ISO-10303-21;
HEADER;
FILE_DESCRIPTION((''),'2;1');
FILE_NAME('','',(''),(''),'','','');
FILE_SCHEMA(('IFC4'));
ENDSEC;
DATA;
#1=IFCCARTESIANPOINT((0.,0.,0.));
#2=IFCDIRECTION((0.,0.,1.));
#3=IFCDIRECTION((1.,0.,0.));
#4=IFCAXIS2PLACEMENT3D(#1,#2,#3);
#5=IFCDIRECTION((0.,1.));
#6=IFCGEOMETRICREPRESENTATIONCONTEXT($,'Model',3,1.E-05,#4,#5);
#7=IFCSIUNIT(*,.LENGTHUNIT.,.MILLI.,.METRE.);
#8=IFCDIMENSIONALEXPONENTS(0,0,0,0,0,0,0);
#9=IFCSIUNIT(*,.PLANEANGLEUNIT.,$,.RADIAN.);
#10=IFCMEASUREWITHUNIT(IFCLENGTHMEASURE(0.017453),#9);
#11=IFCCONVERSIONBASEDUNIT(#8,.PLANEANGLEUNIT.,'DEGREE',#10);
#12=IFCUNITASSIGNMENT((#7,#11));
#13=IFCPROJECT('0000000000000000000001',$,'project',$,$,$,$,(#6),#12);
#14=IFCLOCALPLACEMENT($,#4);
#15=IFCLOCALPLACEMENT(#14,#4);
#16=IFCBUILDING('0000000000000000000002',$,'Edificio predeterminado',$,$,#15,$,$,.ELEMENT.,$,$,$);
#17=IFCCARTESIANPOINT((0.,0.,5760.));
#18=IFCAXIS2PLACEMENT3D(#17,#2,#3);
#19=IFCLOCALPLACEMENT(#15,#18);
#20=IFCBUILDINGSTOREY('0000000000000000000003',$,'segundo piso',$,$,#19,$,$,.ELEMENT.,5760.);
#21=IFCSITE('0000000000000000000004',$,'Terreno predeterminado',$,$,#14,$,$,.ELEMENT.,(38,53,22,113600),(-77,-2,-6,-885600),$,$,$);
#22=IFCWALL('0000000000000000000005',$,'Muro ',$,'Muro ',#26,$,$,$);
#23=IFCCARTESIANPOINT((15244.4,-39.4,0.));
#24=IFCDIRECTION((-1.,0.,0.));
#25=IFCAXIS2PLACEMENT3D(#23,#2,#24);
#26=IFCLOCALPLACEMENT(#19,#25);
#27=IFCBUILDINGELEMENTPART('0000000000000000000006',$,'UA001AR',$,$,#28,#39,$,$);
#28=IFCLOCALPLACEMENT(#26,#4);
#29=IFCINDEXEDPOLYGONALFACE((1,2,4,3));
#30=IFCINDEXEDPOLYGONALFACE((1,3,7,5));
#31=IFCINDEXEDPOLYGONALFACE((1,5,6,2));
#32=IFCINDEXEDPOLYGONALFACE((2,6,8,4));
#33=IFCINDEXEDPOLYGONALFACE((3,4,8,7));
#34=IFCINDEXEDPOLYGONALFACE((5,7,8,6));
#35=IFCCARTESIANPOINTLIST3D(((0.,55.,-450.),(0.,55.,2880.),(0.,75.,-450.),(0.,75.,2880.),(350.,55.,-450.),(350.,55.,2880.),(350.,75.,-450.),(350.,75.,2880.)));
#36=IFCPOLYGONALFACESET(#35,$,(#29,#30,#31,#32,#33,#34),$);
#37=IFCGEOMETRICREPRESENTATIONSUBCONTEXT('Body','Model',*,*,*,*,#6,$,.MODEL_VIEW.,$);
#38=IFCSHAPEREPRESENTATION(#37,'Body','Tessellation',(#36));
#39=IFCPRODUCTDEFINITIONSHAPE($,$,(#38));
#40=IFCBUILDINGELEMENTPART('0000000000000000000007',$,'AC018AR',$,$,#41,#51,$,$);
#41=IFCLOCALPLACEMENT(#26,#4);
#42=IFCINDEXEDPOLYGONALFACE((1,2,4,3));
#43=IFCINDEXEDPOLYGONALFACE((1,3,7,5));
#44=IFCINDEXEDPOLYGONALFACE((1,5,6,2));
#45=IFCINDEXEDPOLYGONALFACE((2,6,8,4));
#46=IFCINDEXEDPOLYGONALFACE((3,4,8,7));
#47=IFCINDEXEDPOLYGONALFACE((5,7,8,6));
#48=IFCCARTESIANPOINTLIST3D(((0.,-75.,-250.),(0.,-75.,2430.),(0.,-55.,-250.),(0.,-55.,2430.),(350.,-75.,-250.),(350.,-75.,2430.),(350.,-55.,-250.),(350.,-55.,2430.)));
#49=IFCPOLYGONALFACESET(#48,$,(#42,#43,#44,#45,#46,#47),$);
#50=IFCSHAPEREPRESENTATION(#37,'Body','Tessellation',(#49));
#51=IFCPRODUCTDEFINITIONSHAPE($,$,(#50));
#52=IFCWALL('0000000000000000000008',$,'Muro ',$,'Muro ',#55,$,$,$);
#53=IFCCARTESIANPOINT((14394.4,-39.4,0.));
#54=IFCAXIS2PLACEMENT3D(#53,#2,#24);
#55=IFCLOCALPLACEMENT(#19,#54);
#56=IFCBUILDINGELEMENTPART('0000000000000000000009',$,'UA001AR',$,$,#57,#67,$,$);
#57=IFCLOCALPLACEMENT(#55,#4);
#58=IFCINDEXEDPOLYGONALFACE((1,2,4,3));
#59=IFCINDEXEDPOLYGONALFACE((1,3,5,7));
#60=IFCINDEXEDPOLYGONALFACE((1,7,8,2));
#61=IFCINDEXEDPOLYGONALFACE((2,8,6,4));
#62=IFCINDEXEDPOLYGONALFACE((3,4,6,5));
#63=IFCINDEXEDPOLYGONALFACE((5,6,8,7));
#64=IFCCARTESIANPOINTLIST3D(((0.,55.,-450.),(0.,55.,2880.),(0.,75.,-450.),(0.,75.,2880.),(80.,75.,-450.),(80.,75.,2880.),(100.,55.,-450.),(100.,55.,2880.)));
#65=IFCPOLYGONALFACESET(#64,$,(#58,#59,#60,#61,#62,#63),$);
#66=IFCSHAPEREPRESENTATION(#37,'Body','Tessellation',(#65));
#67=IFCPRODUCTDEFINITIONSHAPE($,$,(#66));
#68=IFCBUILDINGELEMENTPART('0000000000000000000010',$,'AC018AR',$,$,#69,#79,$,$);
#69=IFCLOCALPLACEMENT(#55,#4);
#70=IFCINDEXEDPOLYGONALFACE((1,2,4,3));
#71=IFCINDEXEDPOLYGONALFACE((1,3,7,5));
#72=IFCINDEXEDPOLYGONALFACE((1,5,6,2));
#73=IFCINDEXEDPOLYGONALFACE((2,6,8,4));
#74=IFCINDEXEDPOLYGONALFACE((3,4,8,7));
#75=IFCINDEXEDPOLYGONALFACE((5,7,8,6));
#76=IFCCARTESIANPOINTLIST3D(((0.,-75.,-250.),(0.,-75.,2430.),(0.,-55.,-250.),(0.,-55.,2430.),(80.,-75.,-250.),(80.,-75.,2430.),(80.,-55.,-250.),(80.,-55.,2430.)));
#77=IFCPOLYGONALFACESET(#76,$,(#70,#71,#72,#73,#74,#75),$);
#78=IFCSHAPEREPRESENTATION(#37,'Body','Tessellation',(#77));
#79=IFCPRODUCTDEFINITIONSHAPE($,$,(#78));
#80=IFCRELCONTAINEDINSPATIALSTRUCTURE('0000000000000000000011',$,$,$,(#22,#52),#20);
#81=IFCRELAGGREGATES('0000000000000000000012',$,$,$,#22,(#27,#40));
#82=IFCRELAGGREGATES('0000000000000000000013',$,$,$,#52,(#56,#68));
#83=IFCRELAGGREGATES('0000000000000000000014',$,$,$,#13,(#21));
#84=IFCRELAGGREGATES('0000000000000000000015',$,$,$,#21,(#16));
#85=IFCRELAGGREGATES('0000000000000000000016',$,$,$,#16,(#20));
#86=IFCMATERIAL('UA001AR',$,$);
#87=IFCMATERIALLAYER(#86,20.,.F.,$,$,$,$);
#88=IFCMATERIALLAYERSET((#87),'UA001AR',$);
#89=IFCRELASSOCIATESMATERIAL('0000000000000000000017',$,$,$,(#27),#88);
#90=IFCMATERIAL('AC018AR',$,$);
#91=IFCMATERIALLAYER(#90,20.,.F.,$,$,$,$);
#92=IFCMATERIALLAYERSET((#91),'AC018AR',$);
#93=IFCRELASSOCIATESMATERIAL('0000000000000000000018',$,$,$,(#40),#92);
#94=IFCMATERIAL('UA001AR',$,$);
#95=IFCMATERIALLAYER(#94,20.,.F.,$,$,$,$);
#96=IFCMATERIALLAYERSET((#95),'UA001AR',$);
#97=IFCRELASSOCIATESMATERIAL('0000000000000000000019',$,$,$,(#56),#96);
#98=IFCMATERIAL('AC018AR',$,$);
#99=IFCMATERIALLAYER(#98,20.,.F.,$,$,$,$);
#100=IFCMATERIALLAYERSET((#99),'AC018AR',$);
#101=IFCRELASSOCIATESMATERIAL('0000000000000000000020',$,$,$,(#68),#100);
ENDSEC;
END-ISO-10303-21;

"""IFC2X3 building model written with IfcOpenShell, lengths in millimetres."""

from ifc_helpers import new_model, entity, si_unit, converted_unit, direction, frame, origin_with_axes, place, context, subcontext, project, spatial, polyline, outline, extrude, material, layer, layer_set, layer_usage, element, aggregate, save


model = new_model("IFC2X3")

# Units and contexts
model_context = context("Model", 3, precision=1e-05, world=origin_with_axes(), true_north=direction((0.0, 1.0)))
body_context = subcontext(model_context, "Body", "Model", "MODEL_VIEW")
ifc_project = project(units=[si_unit("LENGTHUNIT", "METRE", prefix="MILLI"), converted_unit("PLANEANGLEUNIT", "DEGREE", entity("IfcLengthMeasure", 0.017453), si_unit("PLANEANGLEUNIT", "RADIAN"), dimensions=[0, 0, 0, 0, 0, 0, 0])], contexts=[model_context])

# Site, building, storey
site_placement = place(None, origin_with_axes())
site = spatial("IfcSite", under=ifc_project, at=site_placement, Name="Terreno predeterminado", CompositionType="ELEMENT", RefLatitude=(38, 53, 22, 113600), RefLongitude=(-77, -2, -6, -885600))
building_placement = place(site_placement, origin_with_axes())
building = spatial("IfcBuilding", under=site, at=building_placement, Name="Edificio predeterminado", CompositionType="ELEMENT")
storey_placement = place(building_placement, frame((0.0, 0.0, 5760.0), z_axis=(0.0, 0.0, 1.0), x_axis=(1.0, 0.0, 0.0)))
storey = spatial("IfcBuildingStorey", under=building, at=storey_placement, Name="segundo piso", CompositionType="ELEMENT", Elevation=5760.0)

# Walls, building element parts
wall_1_placement = place(storey_placement, frame((15244.4, -39.4, 0.0), z_axis=(0.0, 0.0, 1.0), x_axis=(-1.0, 0.0, 0.0)))
wall_1 = element("IfcWall", 1, at=wall_1_placement, inside=storey, Name="Muro ", ObjectType="Muro ")
ifc_material_1 = material(Name="UA001AR")
ifc_layer_1 = layer(ifc_material_1, 20.0, ventilated=False)
ifc_layer_set_1 = layer_set([ifc_layer_1], Name="UA001AR")
ifc_layer_usage_1 = layer_usage(ifc_layer_set_1, "AXIS2", "NEGATIVE", -75.0)
building_element_part_1_placement = place(wall_1_placement, origin_with_axes())
building_element_part_1 = element("IfcBuildingElementPart", 2, at=building_element_part_1_placement, material=ifc_layer_usage_1, Name="UA001AR", context=body_context, shape_type="SweptSolid", body=[
    extrude(outline(polyline([(350.0, 75.0), (350.0, 55.0), (0.0, 55.0), (0.0, 75.0), (350.0, 75.0)])), frame((0.0, 0.0, -450.0), z_axis=(0.0, 0.0, 1.0), x_axis=(1.0, 0.0, 0.0)), (0.0, 0.0, 1.0), 3330.0),
])
ifc_material_2 = material(Name="AC018AR")
ifc_layer_2 = layer(ifc_material_2, 20.0, ventilated=False)
ifc_layer_set_2 = layer_set([ifc_layer_2], Name="AC018AR")
ifc_layer_usage_2 = layer_usage(ifc_layer_set_2, "AXIS2", "NEGATIVE", 55.0)
building_element_part_2_placement = place(wall_1_placement, origin_with_axes())
building_element_part_2 = element("IfcBuildingElementPart", 3, at=building_element_part_2_placement, material=ifc_layer_usage_2, Name="AC018AR", context=body_context, shape_type="SweptSolid", body=[
    extrude(outline(polyline([(350.0, -55.0), (350.0, -75.0), (0.0, -75.0), (0.0, -55.0), (350.0, -55.0)])), frame((0.0, 0.0, -250.0), z_axis=(0.0, 0.0, 1.0), x_axis=(1.0, 0.0, 0.0)), (0.0, 0.0, 1.0), 2680.0),
])
aggregate(wall_1, [building_element_part_1, building_element_part_2])
wall_2_placement = place(storey_placement, frame((14394.4, -39.4, 0.0), z_axis=(0.0, 0.0, 1.0), x_axis=(-1.0, 0.0, 0.0)))
wall_2 = element("IfcWall", 4, at=wall_2_placement, inside=storey, Name="Muro ", ObjectType="Muro ")
ifc_material_3 = material(Name="UA001AR")
ifc_layer_3 = layer(ifc_material_3, 20.0, ventilated=False)
ifc_layer_set_3 = layer_set([ifc_layer_3], Name="UA001AR")
ifc_layer_usage_3 = layer_usage(ifc_layer_set_3, "AXIS2", "NEGATIVE", -75.0)
building_element_part_3_placement = place(wall_2_placement, origin_with_axes())
building_element_part_3 = element("IfcBuildingElementPart", 5, at=building_element_part_3_placement, material=ifc_layer_usage_3, Name="UA001AR", context=body_context, shape_type="SweptSolid", body=[
    extrude(outline(polyline([(80.0, 75.0), (100.0, 55.0), (0.0, 55.0), (0.0, 75.0), (80.0, 75.0)])), frame((0.0, 0.0, -450.0), z_axis=(0.0, 0.0, 1.0), x_axis=(1.0, 0.0, 0.0)), (0.0, 0.0, 1.0), 3330.0),
])
ifc_material_4 = material(Name="AC018AR")
ifc_layer_4 = layer(ifc_material_4, 20.0, ventilated=False)
ifc_layer_set_4 = layer_set([ifc_layer_4], Name="AC018AR")
ifc_layer_usage_4 = layer_usage(ifc_layer_set_4, "AXIS2", "NEGATIVE", 55.0)
building_element_part_4_placement = place(wall_2_placement, origin_with_axes())
building_element_part_4 = element("IfcBuildingElementPart", 6, at=building_element_part_4_placement, material=ifc_layer_usage_4, Name="AC018AR", context=body_context, shape_type="SweptSolid", body=[
    extrude(outline(polyline([(80.0, -55.0), (80.0, -75.0), (0.0, -75.0), (0.0, -55.0), (80.0, -55.0)])), frame((0.0, 0.0, -250.0), z_axis=(0.0, 0.0, 1.0), x_axis=(1.0, 0.0, 0.0)), (0.0, 0.0, 1.0), 2680.0),
])
aggregate(wall_2, [building_element_part_3, building_element_part_4])

save(model, "model.ifc")
